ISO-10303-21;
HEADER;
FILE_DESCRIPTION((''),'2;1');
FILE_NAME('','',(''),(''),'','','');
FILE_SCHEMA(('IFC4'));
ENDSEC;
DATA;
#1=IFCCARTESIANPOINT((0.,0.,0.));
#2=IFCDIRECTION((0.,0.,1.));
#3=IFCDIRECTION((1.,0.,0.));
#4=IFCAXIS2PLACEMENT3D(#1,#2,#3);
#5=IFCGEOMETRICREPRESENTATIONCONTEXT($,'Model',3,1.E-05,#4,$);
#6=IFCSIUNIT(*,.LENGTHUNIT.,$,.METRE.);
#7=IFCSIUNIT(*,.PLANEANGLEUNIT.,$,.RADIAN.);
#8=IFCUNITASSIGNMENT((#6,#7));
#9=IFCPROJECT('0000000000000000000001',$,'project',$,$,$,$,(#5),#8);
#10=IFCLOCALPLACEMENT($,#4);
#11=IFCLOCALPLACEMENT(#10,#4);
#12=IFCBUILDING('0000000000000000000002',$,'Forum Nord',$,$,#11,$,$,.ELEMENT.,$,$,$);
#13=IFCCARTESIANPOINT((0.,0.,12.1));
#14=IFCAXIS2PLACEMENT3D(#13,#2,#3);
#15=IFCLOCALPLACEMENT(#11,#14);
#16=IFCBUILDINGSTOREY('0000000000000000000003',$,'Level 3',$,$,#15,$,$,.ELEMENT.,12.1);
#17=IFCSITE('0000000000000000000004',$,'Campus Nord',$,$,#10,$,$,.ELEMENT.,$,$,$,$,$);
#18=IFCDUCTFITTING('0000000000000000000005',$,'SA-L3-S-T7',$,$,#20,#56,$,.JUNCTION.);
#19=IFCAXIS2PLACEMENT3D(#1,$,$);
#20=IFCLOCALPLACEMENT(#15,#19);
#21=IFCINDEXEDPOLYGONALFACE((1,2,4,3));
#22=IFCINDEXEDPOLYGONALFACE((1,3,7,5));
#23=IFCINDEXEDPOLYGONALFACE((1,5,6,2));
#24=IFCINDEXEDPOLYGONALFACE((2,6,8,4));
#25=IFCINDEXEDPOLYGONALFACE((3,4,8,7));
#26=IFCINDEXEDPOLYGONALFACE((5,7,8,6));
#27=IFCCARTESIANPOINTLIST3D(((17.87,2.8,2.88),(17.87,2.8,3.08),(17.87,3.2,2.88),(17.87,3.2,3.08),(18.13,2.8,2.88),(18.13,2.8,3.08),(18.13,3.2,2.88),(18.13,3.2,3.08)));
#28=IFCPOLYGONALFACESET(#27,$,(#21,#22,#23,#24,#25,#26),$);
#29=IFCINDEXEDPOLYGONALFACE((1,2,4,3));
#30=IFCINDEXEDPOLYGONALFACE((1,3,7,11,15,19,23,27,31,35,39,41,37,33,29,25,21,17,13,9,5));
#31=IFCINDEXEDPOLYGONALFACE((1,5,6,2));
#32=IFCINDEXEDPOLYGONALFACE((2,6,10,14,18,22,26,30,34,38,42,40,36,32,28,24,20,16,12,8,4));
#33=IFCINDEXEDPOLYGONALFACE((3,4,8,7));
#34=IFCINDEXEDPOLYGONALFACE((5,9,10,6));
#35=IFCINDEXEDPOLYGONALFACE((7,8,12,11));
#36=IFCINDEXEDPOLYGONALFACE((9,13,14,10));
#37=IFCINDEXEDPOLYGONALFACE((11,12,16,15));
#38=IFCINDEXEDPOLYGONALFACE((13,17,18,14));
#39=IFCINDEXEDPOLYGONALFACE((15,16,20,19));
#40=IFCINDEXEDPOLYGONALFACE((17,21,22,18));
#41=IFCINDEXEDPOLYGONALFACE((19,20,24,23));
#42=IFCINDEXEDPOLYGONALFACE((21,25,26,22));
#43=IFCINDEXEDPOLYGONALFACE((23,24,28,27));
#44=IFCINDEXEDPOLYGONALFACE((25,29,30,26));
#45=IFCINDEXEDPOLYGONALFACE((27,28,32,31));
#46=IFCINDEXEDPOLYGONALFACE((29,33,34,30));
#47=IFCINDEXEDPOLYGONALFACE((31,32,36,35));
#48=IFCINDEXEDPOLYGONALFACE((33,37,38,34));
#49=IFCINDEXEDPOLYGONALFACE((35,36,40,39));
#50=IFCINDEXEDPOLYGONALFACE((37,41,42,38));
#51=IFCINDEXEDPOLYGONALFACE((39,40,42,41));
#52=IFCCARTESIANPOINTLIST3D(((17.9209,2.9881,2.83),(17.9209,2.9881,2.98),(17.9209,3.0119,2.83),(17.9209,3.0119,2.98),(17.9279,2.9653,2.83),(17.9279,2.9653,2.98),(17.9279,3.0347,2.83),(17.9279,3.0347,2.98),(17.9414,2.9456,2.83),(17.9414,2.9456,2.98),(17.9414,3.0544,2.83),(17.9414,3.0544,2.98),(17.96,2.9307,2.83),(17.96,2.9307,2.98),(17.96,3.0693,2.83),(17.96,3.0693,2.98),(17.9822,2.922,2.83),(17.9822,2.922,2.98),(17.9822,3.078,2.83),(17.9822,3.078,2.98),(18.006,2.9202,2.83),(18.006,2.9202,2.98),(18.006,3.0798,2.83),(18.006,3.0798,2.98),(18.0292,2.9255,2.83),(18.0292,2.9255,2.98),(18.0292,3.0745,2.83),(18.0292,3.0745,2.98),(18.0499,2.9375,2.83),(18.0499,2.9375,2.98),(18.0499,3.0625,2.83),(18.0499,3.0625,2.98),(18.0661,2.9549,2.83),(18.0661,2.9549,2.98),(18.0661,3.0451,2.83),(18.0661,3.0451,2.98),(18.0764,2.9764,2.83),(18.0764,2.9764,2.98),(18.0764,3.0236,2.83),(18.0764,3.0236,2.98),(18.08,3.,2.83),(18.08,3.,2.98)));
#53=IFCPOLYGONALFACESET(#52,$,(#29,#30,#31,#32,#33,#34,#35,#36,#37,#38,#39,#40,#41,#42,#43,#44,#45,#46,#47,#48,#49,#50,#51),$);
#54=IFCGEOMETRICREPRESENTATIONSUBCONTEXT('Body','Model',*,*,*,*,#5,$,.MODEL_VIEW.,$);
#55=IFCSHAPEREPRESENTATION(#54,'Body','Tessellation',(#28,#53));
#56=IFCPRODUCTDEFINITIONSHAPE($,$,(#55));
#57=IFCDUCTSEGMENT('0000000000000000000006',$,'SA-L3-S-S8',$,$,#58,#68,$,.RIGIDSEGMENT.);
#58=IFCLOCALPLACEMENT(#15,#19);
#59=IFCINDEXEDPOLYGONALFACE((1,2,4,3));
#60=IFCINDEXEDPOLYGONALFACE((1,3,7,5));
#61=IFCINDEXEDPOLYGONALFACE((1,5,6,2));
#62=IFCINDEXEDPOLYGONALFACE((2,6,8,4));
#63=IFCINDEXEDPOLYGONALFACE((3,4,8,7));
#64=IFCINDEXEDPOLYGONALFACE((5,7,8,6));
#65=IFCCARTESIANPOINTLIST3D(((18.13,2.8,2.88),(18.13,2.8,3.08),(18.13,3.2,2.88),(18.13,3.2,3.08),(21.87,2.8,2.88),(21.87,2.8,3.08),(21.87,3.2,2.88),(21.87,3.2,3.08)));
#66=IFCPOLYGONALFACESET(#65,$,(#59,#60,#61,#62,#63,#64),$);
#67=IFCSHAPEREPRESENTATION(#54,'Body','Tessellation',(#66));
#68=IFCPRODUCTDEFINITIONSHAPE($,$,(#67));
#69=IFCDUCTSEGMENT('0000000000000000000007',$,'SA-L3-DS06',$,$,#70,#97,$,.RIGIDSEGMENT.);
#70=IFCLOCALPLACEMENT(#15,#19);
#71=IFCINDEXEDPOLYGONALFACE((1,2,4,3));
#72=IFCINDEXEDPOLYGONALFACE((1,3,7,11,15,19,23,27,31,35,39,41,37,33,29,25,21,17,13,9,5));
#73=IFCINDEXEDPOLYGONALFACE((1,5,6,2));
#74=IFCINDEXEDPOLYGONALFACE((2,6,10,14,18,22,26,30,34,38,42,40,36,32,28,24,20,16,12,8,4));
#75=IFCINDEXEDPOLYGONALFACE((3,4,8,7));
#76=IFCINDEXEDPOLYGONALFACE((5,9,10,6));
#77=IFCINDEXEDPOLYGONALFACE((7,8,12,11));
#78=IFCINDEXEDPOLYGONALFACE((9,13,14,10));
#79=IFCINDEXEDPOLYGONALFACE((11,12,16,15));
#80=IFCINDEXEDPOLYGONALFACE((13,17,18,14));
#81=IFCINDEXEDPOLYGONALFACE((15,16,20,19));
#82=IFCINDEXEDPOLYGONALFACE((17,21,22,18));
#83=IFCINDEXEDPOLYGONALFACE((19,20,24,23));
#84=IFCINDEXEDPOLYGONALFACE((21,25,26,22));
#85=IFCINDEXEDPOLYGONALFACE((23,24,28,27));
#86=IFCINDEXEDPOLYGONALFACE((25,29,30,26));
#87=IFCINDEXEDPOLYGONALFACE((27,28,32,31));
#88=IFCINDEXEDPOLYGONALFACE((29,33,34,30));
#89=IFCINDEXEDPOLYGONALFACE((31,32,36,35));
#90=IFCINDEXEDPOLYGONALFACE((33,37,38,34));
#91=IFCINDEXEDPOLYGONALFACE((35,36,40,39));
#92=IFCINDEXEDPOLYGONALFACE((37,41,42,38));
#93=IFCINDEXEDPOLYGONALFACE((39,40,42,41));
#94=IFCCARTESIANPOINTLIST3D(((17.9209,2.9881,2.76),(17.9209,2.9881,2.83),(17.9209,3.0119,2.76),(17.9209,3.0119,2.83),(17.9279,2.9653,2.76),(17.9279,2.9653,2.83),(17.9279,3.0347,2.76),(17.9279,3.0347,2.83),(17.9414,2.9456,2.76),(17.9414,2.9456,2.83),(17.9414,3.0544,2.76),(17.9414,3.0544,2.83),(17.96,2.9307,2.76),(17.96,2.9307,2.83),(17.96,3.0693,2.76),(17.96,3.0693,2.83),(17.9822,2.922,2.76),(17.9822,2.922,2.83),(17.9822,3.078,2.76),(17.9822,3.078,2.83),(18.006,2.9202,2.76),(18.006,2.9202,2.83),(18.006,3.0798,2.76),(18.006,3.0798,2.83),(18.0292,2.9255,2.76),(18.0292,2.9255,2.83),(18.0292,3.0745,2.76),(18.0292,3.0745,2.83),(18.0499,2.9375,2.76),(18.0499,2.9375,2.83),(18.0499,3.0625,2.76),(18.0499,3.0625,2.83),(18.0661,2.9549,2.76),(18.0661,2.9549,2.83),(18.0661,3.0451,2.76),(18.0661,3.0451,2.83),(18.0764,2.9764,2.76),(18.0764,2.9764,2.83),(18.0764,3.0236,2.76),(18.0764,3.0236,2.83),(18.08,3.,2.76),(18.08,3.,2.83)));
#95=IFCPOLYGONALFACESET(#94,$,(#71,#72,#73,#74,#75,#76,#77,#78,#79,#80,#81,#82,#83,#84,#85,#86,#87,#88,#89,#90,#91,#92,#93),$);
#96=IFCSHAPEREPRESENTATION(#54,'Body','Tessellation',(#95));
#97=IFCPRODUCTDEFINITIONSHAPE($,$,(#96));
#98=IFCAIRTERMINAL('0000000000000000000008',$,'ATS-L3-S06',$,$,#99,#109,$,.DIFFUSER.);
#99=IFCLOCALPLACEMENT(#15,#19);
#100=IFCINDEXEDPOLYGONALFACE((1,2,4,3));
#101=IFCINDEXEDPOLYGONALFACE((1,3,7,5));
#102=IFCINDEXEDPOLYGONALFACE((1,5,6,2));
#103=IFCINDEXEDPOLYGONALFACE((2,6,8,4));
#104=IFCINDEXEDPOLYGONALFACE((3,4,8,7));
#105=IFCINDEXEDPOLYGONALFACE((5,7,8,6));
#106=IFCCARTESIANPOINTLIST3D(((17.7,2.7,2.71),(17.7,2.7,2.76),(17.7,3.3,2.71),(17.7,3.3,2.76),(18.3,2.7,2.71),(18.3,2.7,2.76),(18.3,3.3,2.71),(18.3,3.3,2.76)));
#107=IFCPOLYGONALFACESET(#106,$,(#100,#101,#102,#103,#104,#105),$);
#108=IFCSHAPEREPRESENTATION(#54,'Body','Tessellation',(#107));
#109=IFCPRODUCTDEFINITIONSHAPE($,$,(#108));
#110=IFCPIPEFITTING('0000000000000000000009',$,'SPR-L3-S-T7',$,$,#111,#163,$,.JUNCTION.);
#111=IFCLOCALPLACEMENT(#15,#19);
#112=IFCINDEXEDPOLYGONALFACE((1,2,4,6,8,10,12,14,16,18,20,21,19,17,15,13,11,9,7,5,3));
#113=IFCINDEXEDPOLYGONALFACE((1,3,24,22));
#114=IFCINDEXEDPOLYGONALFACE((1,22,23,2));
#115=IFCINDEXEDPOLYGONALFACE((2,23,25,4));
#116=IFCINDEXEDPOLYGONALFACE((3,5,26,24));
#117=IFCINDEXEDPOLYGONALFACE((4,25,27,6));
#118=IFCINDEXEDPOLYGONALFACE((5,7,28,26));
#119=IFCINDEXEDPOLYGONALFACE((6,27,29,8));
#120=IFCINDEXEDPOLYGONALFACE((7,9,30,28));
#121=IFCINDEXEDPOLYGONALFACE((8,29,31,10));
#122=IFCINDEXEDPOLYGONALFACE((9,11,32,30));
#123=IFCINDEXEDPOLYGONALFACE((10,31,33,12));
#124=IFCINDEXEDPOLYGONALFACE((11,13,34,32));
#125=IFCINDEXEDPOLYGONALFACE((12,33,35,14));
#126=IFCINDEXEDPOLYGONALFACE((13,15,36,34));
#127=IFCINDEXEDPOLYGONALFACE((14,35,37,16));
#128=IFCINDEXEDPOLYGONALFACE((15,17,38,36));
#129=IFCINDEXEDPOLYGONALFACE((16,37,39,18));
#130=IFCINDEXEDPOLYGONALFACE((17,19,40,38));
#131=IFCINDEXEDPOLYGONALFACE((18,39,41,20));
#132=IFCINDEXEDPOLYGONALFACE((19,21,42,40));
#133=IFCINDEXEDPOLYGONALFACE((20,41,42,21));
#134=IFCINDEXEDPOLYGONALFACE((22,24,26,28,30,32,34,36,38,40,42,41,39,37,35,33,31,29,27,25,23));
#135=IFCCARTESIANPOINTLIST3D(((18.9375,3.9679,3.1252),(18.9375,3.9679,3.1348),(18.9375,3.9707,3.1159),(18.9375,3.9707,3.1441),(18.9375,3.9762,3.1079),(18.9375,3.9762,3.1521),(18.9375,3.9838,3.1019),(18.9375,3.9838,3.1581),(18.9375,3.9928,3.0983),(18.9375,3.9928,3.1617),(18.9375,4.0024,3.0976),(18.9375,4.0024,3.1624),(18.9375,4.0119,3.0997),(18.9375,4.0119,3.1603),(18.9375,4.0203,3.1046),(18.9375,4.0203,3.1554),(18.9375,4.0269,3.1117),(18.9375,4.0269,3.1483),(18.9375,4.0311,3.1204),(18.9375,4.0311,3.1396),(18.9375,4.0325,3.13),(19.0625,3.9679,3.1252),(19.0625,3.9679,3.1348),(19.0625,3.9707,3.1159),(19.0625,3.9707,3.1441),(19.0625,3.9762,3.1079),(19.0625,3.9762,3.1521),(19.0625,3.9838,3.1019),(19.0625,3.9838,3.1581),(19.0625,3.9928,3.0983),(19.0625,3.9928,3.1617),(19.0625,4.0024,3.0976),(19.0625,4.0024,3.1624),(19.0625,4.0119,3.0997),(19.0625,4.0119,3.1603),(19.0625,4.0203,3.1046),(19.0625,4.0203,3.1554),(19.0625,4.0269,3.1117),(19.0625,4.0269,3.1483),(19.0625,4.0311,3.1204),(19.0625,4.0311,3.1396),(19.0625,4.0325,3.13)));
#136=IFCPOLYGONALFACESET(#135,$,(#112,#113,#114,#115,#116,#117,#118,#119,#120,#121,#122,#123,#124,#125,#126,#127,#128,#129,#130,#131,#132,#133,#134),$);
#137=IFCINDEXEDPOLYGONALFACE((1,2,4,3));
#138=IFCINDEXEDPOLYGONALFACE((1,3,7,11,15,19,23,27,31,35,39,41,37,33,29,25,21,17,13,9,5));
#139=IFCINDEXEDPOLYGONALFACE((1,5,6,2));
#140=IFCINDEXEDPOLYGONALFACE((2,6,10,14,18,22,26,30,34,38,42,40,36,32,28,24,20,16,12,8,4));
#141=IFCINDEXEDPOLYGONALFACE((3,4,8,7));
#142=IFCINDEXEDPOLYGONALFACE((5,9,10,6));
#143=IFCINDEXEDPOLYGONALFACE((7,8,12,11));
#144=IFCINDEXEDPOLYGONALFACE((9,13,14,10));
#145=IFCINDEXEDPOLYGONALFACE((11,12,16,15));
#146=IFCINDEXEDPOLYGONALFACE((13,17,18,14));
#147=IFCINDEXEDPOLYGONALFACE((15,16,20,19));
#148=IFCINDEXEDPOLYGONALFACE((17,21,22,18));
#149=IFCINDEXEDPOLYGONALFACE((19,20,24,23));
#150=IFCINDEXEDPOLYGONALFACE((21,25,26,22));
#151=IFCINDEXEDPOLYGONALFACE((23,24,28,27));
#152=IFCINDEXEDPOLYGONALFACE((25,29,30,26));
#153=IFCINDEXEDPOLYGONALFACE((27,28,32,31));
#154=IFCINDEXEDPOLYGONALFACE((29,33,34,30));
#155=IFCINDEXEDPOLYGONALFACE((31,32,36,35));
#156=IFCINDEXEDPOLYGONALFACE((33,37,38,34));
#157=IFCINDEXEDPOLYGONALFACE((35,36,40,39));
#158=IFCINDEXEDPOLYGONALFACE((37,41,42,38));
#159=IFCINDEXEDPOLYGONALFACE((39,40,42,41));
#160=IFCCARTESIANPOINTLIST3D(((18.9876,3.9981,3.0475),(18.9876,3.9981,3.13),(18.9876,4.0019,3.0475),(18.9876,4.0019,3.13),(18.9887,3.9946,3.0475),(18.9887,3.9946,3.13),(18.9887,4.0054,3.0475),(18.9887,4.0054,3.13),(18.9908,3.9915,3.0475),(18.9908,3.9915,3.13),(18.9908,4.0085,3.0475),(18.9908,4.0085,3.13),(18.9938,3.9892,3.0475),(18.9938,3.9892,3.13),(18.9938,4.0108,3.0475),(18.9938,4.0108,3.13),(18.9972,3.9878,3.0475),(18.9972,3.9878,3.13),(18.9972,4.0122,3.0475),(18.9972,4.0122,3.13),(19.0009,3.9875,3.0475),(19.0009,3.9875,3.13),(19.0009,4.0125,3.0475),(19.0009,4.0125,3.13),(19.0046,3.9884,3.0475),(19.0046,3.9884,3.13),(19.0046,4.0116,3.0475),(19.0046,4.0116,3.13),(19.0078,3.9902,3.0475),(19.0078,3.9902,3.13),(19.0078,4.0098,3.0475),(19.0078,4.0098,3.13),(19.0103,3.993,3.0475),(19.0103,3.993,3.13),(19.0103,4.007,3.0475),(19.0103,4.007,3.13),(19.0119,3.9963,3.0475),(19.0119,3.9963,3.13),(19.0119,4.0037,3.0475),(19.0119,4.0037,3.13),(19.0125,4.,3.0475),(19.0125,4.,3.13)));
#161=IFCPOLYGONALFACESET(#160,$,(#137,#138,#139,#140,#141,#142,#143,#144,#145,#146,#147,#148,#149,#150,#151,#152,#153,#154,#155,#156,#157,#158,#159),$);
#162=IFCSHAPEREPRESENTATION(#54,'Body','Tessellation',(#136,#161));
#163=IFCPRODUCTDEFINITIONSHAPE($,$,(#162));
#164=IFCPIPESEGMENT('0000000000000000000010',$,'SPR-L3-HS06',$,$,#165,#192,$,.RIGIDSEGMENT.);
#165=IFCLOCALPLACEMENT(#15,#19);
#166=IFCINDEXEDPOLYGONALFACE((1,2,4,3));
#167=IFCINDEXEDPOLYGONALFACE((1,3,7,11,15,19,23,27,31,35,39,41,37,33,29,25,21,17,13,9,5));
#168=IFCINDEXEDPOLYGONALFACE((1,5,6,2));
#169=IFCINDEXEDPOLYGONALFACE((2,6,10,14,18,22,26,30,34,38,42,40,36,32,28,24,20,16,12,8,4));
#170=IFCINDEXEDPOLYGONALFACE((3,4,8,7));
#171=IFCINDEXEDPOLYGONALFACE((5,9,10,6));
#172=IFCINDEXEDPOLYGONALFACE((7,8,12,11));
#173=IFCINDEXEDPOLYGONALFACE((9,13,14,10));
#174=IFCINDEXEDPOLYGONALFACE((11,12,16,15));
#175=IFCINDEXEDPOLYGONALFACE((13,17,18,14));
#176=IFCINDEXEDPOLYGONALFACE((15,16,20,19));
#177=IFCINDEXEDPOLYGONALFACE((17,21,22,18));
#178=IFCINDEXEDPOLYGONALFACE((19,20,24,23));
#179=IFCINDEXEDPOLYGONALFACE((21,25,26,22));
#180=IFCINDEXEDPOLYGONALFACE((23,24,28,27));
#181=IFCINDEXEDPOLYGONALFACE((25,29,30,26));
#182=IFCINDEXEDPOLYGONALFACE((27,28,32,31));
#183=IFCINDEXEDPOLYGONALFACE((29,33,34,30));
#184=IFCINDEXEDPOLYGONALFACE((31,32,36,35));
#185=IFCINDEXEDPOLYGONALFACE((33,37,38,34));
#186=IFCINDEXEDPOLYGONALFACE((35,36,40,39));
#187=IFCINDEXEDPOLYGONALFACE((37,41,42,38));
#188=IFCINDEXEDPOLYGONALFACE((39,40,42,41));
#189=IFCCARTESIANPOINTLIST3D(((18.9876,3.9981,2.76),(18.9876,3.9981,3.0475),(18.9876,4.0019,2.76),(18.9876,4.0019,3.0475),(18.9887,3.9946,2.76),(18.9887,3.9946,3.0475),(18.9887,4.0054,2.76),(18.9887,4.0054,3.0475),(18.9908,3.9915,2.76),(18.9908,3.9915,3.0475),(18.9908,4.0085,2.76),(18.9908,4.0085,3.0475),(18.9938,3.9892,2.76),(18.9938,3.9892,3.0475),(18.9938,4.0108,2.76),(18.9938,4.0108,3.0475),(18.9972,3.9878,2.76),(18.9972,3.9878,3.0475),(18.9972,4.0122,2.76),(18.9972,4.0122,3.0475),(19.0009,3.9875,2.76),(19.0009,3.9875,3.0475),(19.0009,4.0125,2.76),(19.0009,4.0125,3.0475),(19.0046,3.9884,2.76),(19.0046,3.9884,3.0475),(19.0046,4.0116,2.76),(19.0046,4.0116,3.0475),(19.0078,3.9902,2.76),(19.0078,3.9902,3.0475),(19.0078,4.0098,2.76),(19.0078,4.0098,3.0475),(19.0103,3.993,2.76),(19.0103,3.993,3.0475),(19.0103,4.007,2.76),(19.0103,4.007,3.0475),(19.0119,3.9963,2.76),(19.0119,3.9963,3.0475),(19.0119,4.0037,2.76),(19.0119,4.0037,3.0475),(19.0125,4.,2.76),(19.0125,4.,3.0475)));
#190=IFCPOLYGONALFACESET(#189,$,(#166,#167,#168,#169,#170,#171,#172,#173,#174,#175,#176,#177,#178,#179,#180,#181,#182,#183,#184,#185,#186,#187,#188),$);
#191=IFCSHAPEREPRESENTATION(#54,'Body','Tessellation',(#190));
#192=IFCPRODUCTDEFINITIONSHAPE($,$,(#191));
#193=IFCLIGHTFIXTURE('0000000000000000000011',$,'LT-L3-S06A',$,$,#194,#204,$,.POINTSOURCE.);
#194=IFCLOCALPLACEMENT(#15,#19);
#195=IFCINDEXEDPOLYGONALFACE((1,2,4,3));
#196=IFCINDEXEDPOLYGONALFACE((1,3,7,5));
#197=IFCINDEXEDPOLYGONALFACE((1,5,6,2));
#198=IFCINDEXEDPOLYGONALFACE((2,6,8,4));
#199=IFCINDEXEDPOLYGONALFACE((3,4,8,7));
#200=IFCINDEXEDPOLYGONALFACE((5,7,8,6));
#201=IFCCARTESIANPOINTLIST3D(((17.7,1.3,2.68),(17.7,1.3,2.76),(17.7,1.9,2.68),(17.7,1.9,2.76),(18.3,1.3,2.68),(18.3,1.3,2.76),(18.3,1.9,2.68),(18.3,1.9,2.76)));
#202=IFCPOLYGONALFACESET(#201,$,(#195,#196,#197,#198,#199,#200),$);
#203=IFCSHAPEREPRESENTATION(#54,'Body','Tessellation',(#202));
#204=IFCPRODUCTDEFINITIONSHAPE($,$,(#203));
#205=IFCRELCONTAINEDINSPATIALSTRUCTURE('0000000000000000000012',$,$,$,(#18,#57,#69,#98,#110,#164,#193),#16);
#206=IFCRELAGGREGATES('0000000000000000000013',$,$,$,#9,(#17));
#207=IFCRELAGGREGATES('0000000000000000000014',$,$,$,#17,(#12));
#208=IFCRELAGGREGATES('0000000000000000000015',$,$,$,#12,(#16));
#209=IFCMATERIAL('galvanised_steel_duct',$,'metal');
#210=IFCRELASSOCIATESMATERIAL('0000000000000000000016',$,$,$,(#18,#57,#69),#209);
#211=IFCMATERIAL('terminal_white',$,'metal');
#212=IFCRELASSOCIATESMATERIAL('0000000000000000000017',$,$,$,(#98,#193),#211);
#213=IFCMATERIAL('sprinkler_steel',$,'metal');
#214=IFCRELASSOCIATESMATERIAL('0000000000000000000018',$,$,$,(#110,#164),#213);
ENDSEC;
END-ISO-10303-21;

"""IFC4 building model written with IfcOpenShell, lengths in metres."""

from ifc_helpers import new_model, si_unit, frame, origin_with_axes, origin_2d_with_axis, place, context, subcontext, project, spatial, rectangle, circle, extrude, material, element, save


model = new_model("IFC4")

# Units and contexts
model_context = context("Model", 3, precision=1e-05, world=origin_with_axes())
body_context = subcontext(model_context, "Body", "Model", "MODEL_VIEW")
ifc_project = project(units=[si_unit("LENGTHUNIT", "METRE"), si_unit("PLANEANGLEUNIT", "RADIAN")], contexts=[model_context])

# Site, building, storey
site_placement = place(None, origin_with_axes())
site = spatial("IfcSite", under=ifc_project, at=site_placement, Name="Campus Nord", CompositionType="ELEMENT")
building_placement = place(site_placement, origin_with_axes())
building = spatial("IfcBuilding", under=site, at=building_placement, Name="Forum Nord", CompositionType="ELEMENT")
storey_placement = place(building_placement, frame((0.0, 0.0, 12.1), z_axis=(0.0, 0.0, 1.0), x_axis=(1.0, 0.0, 0.0)))
storey = spatial("IfcBuildingStorey", under=building, at=storey_placement, Name="Level 3", CompositionType="ELEMENT", Elevation=12.1)

# Duct fitting
ifc_material_1 = material(Name="galvanised_steel_duct", Category="metal")
duct_fitting_placement = place(storey_placement, frame((17.87, 3.0, 2.98), z_axis=(1.0, 0.0, 0.0), x_axis=(0.0, 1.0, 0.0)))
element("IfcDuctFitting", 1, at=duct_fitting_placement, inside=storey, material=ifc_material_1, Name="SA-L3-S-T7", PredefinedType="JUNCTION", context=body_context, shape_type="SweptSolid", body=[
    extrude(rectangle(XDim=0.4, YDim=0.2, at=origin_2d_with_axis()), origin_with_axes(), (0.0, 0.0, 1.0), 0.26),
    extrude(circle(Radius=0.08, at=origin_2d_with_axis()), frame((0.0, 0.0, 0.13), z_axis=(0.0, -1.0, 0.0), x_axis=(0.0, 0.0, 1.0)), (0.0, 0.0, 1.0), 0.15),
])

# Duct segments
duct_segment_1_placement = place(storey_placement, frame((18.13, 3.0, 2.98), z_axis=(1.0, 0.0, 0.0), x_axis=(0.0, 1.0, 0.0)))
element("IfcDuctSegment", 2, at=duct_segment_1_placement, inside=storey, material=ifc_material_1, Name="SA-L3-S-S8", PredefinedType="RIGIDSEGMENT", context=body_context, shape_type="SweptSolid", body=[
    extrude(rectangle(XDim=0.4, YDim=0.2, at=origin_2d_with_axis()), origin_with_axes(), (0.0, 0.0, 1.0), 3.74),
])
duct_segment_2_placement = place(storey_placement, frame((18.0, 3.0, 2.83), z_axis=(0.0, 0.0, -1.0), x_axis=(1.0, 0.0, 0.0)))
element("IfcDuctSegment", 3, at=duct_segment_2_placement, inside=storey, material=ifc_material_1, Name="SA-L3-DS06", PredefinedType="RIGIDSEGMENT", context=body_context, shape_type="SweptSolid", body=[
    extrude(circle(Radius=0.08, at=origin_2d_with_axis()), origin_with_axes(), (0.0, 0.0, 1.0), 0.07),
])

# Air terminal
ifc_material_2 = material(Name="terminal_white", Category="metal")
air_terminal_placement = place(storey_placement, frame((18.0, 3.0, 2.71), z_axis=(0.0, 0.0, 1.0), x_axis=(1.0, 0.0, 0.0)))
element("IfcAirTerminal", 4, at=air_terminal_placement, inside=storey, material=ifc_material_2, Name="ATS-L3-S06", PredefinedType="DIFFUSER", context=body_context, shape_type="SweptSolid", body=[
    extrude(rectangle(XDim=0.6, YDim=0.6, at=origin_2d_with_axis()), origin_with_axes(), (0.0, 0.0, 1.0), 0.05),
])

# Pipe fitting
ifc_material_3 = material(Name="sprinkler_steel", Category="metal")
pipe_fitting_placement = place(storey_placement, frame((18.9375, 4.0, 3.13), z_axis=(1.0, 0.0, 0.0), x_axis=(0.0, 1.0, 0.0)))
element("IfcPipeFitting", 5, at=pipe_fitting_placement, inside=storey, material=ifc_material_3, Name="SPR-L3-S-T7", PredefinedType="JUNCTION", context=body_context, shape_type="SweptSolid", body=[
    extrude(circle(Radius=0.0325, at=origin_2d_with_axis()), origin_with_axes(), (0.0, 0.0, 1.0), 0.125),
    extrude(circle(Radius=0.0125, at=origin_2d_with_axis()), frame((0.0, 0.0, 0.0625), z_axis=(0.0, -1.0, 0.0), x_axis=(0.0, 0.0, 1.0)), (0.0, 0.0, 1.0), 0.0825),
])

# Pipe segment
pipe_segment_placement = place(storey_placement, frame((19.0, 4.0, 3.0475), z_axis=(0.0, 0.0, -1.0), x_axis=(1.0, 0.0, 0.0)))
element("IfcPipeSegment", 6, at=pipe_segment_placement, inside=storey, material=ifc_material_3, Name="SPR-L3-HS06", PredefinedType="RIGIDSEGMENT", context=body_context, shape_type="SweptSolid", body=[
    extrude(circle(Radius=0.0125, at=origin_2d_with_axis()), origin_with_axes(), (0.0, 0.0, 1.0), 0.2875),
])

# Light fixture
light_fixture_placement = place(storey_placement, frame((18.0, 1.6, 2.68), z_axis=(0.0, 0.0, 1.0), x_axis=(1.0, 0.0, 0.0)))
element("IfcLightFixture", 7, at=light_fixture_placement, inside=storey, material=ifc_material_2, Name="LT-L3-S06A", PredefinedType="POINTSOURCE", context=body_context, shape_type="SweptSolid", body=[
    extrude(rectangle(XDim=0.6, YDim=0.6, at=origin_2d_with_axis()), origin_with_axes(), (0.0, 0.0, 1.0), 0.08),
])

save(model, "model.ifc")
